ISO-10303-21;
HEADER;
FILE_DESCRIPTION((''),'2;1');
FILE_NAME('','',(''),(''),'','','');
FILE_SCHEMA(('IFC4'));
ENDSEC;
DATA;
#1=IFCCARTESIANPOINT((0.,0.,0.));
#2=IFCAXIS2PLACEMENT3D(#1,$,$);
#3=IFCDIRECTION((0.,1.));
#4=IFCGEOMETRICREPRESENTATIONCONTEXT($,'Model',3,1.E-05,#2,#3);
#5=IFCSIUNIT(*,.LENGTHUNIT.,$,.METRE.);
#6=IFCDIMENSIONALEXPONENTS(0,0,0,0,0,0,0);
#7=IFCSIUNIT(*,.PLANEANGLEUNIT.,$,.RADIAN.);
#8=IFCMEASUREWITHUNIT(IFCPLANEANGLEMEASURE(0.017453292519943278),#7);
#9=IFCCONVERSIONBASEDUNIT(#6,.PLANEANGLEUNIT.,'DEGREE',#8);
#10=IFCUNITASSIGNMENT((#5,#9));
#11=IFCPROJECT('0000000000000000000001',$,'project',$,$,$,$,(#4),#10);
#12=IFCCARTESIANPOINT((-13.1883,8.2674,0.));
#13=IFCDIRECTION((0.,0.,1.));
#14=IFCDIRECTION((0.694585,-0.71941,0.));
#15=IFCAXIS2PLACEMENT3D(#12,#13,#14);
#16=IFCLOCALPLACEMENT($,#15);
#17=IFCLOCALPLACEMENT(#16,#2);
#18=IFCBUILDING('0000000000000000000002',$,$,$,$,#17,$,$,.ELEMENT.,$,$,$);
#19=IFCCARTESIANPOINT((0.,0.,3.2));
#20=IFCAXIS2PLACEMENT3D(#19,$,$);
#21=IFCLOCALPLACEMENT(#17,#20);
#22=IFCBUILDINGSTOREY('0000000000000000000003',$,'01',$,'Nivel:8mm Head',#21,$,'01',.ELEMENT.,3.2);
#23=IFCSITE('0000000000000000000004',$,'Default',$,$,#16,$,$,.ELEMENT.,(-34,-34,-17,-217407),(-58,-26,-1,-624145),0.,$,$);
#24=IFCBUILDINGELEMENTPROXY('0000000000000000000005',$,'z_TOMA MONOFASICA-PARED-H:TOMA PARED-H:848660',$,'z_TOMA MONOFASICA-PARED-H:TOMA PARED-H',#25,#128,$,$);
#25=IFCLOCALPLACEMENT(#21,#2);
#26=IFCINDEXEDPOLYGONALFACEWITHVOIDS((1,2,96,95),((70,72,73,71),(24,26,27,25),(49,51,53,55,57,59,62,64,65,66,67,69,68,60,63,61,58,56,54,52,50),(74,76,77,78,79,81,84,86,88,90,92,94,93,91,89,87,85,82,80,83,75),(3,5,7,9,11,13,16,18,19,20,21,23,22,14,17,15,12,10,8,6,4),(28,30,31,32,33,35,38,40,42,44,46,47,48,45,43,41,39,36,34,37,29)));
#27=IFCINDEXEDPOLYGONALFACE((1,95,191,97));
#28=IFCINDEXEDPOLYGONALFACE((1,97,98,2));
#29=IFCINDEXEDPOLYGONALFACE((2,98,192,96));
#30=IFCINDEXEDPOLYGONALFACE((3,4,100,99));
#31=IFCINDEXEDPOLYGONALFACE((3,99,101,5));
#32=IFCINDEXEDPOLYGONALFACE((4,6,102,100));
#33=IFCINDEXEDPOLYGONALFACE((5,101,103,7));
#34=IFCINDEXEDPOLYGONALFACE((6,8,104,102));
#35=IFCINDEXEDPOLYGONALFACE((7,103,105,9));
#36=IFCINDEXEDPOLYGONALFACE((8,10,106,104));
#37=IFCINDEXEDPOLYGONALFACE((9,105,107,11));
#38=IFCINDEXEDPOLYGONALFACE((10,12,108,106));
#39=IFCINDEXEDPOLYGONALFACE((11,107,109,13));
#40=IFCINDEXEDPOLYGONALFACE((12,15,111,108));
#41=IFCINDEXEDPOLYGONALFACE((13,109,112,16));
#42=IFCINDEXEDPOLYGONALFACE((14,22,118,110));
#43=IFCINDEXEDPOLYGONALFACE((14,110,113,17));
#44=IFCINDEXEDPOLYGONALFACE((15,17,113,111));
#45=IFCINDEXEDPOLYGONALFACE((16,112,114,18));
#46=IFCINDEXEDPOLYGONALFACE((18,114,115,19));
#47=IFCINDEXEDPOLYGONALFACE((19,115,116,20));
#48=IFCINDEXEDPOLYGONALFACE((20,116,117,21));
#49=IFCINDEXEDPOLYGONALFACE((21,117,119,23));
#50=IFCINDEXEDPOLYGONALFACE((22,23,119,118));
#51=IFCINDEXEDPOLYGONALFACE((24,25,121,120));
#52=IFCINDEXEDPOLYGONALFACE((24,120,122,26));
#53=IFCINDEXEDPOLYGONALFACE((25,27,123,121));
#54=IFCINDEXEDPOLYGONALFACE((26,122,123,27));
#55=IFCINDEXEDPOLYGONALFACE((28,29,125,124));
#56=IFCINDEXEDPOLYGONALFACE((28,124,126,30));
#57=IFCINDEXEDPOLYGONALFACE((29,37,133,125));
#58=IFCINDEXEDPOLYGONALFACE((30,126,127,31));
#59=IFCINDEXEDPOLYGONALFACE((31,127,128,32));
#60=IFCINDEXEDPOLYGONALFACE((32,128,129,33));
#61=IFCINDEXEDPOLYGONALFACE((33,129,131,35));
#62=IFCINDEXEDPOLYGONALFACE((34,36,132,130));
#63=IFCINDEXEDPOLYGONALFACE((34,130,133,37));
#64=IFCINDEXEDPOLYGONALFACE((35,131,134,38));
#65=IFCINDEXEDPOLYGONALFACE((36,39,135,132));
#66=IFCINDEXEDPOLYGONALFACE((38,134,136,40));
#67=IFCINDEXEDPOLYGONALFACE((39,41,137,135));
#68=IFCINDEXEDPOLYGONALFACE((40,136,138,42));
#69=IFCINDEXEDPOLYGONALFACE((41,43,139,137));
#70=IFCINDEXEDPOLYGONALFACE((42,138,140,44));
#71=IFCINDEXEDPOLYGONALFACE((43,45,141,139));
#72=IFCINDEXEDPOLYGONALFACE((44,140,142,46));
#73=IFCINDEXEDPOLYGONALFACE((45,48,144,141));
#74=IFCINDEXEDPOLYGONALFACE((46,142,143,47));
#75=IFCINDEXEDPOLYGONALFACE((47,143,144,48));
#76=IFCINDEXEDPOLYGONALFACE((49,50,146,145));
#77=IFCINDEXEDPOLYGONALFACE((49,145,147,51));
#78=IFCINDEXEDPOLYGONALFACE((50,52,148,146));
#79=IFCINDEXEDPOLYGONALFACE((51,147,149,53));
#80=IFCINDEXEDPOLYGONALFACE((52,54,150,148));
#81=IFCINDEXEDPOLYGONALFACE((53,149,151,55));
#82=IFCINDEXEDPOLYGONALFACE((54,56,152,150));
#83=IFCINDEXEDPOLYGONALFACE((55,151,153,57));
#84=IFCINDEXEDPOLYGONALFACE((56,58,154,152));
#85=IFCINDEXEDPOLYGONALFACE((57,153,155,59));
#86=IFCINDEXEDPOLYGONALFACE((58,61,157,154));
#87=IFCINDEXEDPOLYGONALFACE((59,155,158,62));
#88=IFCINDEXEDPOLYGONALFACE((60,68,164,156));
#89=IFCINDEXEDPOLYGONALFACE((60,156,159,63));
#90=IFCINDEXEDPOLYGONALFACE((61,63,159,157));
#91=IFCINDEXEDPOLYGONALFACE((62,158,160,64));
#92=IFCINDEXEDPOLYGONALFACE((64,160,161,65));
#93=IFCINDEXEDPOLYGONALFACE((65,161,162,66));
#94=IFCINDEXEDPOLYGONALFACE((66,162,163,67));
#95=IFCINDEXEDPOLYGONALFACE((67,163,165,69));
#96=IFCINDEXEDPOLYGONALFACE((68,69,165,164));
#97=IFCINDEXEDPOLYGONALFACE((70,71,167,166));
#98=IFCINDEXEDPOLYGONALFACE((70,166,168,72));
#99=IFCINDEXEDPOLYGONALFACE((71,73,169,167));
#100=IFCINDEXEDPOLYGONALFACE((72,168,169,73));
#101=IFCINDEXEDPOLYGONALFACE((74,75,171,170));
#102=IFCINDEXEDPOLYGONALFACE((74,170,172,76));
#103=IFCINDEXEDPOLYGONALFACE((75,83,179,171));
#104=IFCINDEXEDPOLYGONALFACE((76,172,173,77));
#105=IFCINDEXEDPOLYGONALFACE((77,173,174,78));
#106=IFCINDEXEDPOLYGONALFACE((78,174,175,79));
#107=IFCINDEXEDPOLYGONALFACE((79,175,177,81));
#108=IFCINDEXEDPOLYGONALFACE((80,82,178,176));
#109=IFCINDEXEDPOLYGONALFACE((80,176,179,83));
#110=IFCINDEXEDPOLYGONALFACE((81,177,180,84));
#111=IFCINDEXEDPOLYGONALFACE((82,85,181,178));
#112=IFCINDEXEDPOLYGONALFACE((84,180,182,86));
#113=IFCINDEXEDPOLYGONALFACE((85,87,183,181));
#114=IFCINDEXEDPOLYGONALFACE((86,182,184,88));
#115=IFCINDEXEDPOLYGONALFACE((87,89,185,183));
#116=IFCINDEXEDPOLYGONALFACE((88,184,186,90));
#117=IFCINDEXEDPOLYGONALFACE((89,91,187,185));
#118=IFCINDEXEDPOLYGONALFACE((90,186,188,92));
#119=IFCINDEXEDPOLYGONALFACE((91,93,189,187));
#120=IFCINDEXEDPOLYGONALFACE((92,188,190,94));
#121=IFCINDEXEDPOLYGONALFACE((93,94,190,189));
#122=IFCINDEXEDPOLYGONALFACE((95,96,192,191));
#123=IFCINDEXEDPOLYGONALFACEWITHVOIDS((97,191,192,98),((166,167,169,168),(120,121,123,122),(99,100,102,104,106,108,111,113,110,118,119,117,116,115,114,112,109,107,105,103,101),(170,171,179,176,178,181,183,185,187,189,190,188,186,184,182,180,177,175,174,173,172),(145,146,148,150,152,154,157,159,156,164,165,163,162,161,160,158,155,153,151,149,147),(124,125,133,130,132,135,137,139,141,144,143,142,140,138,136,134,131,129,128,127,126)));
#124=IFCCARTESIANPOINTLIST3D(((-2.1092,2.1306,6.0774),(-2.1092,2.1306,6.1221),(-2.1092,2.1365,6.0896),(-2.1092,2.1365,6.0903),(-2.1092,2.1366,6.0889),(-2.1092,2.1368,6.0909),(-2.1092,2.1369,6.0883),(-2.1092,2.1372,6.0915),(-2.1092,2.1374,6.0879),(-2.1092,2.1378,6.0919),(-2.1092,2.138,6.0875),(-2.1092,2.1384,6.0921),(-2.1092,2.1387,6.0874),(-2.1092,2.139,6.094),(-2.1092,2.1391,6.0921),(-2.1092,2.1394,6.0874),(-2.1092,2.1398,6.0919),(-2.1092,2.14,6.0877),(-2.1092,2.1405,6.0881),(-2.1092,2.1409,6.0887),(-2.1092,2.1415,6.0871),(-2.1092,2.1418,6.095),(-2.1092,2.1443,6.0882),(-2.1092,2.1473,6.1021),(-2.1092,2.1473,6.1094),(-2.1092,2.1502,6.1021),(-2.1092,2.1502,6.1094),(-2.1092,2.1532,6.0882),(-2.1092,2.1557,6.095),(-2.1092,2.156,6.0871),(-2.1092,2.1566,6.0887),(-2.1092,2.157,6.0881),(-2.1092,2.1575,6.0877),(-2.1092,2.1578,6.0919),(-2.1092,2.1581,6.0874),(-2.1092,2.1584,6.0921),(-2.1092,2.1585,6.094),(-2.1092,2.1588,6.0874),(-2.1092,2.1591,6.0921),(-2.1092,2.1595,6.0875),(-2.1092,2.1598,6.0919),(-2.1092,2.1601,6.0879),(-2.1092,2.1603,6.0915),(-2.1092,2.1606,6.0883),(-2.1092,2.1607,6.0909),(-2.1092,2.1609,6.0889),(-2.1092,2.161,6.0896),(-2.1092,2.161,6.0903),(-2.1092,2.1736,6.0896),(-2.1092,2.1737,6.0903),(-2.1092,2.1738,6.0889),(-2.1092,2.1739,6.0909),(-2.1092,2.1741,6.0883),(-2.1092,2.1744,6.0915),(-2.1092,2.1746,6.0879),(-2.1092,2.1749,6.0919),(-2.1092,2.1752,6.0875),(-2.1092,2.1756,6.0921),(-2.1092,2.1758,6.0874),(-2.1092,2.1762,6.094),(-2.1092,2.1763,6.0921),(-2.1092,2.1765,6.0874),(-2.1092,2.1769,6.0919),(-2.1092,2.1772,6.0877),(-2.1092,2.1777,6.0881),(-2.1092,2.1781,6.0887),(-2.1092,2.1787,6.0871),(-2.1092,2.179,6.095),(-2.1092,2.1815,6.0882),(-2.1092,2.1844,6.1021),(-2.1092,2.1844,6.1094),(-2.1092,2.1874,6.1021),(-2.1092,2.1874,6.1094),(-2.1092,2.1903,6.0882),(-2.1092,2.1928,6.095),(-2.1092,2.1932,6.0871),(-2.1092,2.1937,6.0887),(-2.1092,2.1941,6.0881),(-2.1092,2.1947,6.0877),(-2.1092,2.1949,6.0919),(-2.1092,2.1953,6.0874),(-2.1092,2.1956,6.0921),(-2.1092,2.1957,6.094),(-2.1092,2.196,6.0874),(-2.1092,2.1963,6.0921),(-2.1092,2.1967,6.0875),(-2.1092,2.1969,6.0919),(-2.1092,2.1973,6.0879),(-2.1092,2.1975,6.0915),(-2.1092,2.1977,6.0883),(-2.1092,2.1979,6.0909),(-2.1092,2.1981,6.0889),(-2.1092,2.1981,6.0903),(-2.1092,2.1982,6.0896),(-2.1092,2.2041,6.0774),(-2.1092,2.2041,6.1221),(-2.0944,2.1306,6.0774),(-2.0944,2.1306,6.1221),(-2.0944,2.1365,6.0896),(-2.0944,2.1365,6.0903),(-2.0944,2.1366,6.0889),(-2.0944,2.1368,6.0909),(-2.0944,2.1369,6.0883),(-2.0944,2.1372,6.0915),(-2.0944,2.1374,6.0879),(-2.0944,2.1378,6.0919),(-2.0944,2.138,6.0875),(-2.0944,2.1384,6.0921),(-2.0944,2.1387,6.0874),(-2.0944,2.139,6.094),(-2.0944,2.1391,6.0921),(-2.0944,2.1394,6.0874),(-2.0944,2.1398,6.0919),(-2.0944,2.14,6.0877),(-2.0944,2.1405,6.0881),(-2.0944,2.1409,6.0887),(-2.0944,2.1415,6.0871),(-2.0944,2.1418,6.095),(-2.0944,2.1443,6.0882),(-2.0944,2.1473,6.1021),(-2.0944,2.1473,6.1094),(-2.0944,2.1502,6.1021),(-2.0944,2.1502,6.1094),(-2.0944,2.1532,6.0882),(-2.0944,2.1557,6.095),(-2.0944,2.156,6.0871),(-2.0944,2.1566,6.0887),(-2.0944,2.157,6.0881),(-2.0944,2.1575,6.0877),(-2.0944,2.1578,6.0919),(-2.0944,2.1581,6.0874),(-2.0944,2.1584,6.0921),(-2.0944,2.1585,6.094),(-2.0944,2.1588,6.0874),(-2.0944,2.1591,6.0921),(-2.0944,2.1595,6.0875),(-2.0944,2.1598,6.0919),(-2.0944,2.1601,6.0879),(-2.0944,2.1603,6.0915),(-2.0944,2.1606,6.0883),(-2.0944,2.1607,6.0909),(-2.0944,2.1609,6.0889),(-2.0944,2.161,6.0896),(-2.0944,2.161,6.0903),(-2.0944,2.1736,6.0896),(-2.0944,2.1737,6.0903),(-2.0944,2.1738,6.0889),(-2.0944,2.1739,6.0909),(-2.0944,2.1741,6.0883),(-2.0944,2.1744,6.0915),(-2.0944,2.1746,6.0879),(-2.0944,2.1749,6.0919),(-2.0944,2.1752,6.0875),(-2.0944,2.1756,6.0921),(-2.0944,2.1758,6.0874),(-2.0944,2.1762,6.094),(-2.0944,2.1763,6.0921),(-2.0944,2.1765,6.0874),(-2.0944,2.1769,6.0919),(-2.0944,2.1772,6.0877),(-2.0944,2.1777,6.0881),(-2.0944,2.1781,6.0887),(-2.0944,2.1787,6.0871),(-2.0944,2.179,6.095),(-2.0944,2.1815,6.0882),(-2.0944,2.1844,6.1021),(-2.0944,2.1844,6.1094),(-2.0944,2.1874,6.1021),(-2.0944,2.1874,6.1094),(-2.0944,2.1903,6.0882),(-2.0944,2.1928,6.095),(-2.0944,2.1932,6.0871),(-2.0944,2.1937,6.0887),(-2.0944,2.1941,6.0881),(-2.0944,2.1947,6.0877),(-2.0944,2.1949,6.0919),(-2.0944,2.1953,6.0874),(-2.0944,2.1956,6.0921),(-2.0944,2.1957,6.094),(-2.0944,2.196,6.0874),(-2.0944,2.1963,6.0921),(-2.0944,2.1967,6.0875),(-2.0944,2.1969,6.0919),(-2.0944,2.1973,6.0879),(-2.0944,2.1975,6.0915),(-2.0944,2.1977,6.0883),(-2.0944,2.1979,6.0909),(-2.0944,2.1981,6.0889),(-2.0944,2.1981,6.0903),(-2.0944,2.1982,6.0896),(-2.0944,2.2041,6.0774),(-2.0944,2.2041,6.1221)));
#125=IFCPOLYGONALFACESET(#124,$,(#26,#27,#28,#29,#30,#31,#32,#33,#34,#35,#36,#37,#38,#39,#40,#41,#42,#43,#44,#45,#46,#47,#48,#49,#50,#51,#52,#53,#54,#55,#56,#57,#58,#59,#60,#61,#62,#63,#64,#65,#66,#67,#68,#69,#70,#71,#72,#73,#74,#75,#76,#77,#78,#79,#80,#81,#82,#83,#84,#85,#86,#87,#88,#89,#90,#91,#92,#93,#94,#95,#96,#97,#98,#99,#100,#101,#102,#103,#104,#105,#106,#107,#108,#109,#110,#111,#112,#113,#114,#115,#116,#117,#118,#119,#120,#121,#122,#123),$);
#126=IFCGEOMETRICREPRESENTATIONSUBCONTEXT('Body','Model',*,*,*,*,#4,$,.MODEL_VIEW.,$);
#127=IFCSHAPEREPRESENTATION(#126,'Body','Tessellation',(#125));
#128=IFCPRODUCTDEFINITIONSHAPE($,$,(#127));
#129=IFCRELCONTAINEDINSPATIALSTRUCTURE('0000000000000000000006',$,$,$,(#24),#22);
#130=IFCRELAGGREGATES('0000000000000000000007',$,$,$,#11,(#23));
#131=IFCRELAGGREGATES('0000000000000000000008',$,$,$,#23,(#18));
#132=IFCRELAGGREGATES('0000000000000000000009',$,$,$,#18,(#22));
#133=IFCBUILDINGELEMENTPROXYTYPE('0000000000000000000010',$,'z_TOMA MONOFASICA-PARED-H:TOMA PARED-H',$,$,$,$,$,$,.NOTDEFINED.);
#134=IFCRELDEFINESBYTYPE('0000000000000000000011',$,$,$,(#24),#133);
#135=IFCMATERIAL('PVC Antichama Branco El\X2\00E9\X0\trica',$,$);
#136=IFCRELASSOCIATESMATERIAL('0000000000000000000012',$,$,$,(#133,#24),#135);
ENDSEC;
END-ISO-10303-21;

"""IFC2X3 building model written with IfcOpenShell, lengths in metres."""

from ifc_helpers import new_model, entity, si_unit, converted_unit, direction, frame, frame_2d, origin, place, context, subcontext, project, spatial, polyline, circle_curve, parameter, trimmed, segment, composite_curve, outline, extrude, source, transform, mapped, material, type_object, type_shapes, element, save


model = new_model("IFC2X3")

# Units and contexts
model_context = context("Model", 3, precision=1e-05, world=origin(), true_north=direction((0.0, 1.0)))
body_context = subcontext(model_context, "Body", "Model", "MODEL_VIEW")
ifc_project = project(units=[si_unit("LENGTHUNIT", "METRE"), converted_unit("PLANEANGLEUNIT", "DEGREE", entity("IfcPlaneAngleMeasure", 0.017453292519943278), si_unit("PLANEANGLEUNIT", "RADIAN"), dimensions=[0, 0, 0, 0, 0, 0, 0])], contexts=[model_context])

# Site, building, storey
site_placement = place(None, frame((-13.1883, 8.2674, 0.0), z_axis=(0.0, 0.0, 1.0), x_axis=(0.694585, -0.71941, 0.0)))
site = spatial("IfcSite", under=ifc_project, at=site_placement, Name="Default", CompositionType="ELEMENT", RefLatitude=(-34, -34, -17, -217407), RefLongitude=(-58, -26, -1, -624145), RefElevation=0.0)
building_placement = place(site_placement, origin())
building = spatial("IfcBuilding", under=site, at=building_placement, CompositionType="ELEMENT")
storey_placement = place(building_placement, frame((0.0, 0.0, 3.2)))
storey = spatial("IfcBuildingStorey", under=building, at=storey_placement, Name="01", ObjectType="Nivel:8mm Head", LongName="01", CompositionType="ELEMENT", Elevation=3.2)

# Building element proxy
ifc_material_1 = material(Name="PVC Antichama Branco Elétrica")
building_element_proxy_type_1 = type_object("IfcBuildingElementProxyType", Name="z_TOMA MONOFASICA-PARED-H:TOMA PARED-H", PredefinedType="NOTDEFINED", material=ifc_material_1)
shared_shape_1 = source(origin(), body_context, "Body", "SweptSolid", [
    extrude(outline(polyline([(-0.0368, -0.0223), (0.0368, -0.0223), (0.0368, 0.0223), (-0.0368, 0.0223), (-0.0368, -0.0223)]), holes=[composite_curve([segment(polyline([(0.0141, 0.0115), (0.0116, 0.0047)]), True, "CONTINUOUS"), segment(polyline([(0.0116, 0.0047), (0.0088, 0.0057)]), True, "CONTINUOUS"), segment(polyline([(0.0088, 0.0057), (0.0096, 0.0078)]), True, "CONTINUOUS"), segment(trimmed(circle_curve(frame_2d((0.0087, 0.0099), x_axis=(1.0, 0.0)), 0.0024), [parameter(27.118901)], [parameter(292.881099)], True, "PARAMETER"), False, "CONTINUOUS"), segment(polyline([(0.0108, 0.011), (0.0113, 0.0126)]), True, "CONTINUOUS"), segment(polyline([(0.0113, 0.0126), (0.0141, 0.0115)]), True, "CONTINUOUS")], self_intersect=False), composite_curve([segment(polyline([(0.0255, 0.0047), (0.023, 0.0115)]), True, "CONTINUOUS"), segment(polyline([(0.023, 0.0115), (0.0258, 0.0126)]), True, "CONTINUOUS"), segment(polyline([(0.0258, 0.0126), (0.0264, 0.011)]), True, "CONTINUOUS"), segment(trimmed(circle_curve(frame_2d((0.0285, 0.0099), x_axis=(1.0, 0.0)), 0.0024), [parameter(247.118901)], [parameter(152.881099)], True, "PARAMETER"), False, "CONTINUOUS"), segment(polyline([(0.0276, 0.0078), (0.0283, 0.0057)]), True, "CONTINUOUS"), segment(polyline([(0.0283, 0.0057), (0.0255, 0.0047)]), True, "CONTINUOUS")], self_intersect=False), polyline([(0.0201, -0.0024), (0.0201, -0.0097), (0.0171, -0.0097), (0.0171, -0.0024), (0.0201, -0.0024)]), composite_curve([segment(polyline([(-0.0141, 0.0115), (-0.0113, 0.0126)]), True, "CONTINUOUS"), segment(polyline([(-0.0113, 0.0126), (-0.0108, 0.011)]), True, "CONTINUOUS"), segment(trimmed(circle_curve(frame_2d((-0.0087, 0.0099), x_axis=(1.0, 0.0)), 0.0024), [parameter(247.118901)], [parameter(152.881099)], True, "PARAMETER"), False, "CONTINUOUS"), segment(polyline([(-0.0096, 0.0078), (-0.0088, 0.0057)]), True, "CONTINUOUS"), segment(polyline([(-0.0088, 0.0057), (-0.0116, 0.0047)]), True, "CONTINUOUS"), segment(polyline([(-0.0116, 0.0047), (-0.0141, 0.0115)]), True, "CONTINUOUS")], self_intersect=False), composite_curve([segment(polyline([(-0.0255, 0.0047), (-0.0283, 0.0057)]), True, "CONTINUOUS"), segment(polyline([(-0.0283, 0.0057), (-0.0276, 0.0078)]), True, "CONTINUOUS"), segment(trimmed(circle_curve(frame_2d((-0.0285, 0.0099), x_axis=(1.0, 0.0)), 0.0024), [parameter(27.118901)], [parameter(292.881099)], True, "PARAMETER"), False, "CONTINUOUS"), segment(polyline([(-0.0264, 0.011), (-0.0258, 0.0126)]), True, "CONTINUOUS"), segment(polyline([(-0.0258, 0.0126), (-0.023, 0.0115)]), True, "CONTINUOUS"), segment(polyline([(-0.023, 0.0115), (-0.0255, 0.0047)]), True, "CONTINUOUS")], self_intersect=False), polyline([(-0.0201, -0.0024), (-0.0171, -0.0024), (-0.0171, -0.0097), (-0.0201, -0.0097), (-0.0201, -0.0024)])]), frame((0.0, -0.005, 0.0223), z_axis=(0.0, 1.0, 0.0), x_axis=(1.0, 0.0, 0.0)), (0.0, 0.0, 1.0), 0.0148),
])
type_shapes(building_element_proxy_type_1, [shared_shape_1])
for number, where, z_axis, x_axis, name in (
    (1, (-2.0994, 2.1673, 6.0774), (0.0, 0.0, 1.0), (0.0, 1.0, 0.0), "z_TOMA MONOFASICA-PARED-H:TOMA PARED-H:848660"),
):
    element("IfcBuildingElementProxy", number, at=place(storey_placement, frame(where, z_axis=z_axis, x_axis=x_axis)), inside=storey, type_object=building_element_proxy_type_1, material=ifc_material_1, Name=name, ObjectType="z_TOMA MONOFASICA-PARED-H:TOMA PARED-H", context=body_context, shape_type="MappedRepresentation", body=[
        mapped(shared_shape_1, transform((0.0, 0.0, 0.0), scale=1.0)),
    ])

save(model, "model.ifc")
